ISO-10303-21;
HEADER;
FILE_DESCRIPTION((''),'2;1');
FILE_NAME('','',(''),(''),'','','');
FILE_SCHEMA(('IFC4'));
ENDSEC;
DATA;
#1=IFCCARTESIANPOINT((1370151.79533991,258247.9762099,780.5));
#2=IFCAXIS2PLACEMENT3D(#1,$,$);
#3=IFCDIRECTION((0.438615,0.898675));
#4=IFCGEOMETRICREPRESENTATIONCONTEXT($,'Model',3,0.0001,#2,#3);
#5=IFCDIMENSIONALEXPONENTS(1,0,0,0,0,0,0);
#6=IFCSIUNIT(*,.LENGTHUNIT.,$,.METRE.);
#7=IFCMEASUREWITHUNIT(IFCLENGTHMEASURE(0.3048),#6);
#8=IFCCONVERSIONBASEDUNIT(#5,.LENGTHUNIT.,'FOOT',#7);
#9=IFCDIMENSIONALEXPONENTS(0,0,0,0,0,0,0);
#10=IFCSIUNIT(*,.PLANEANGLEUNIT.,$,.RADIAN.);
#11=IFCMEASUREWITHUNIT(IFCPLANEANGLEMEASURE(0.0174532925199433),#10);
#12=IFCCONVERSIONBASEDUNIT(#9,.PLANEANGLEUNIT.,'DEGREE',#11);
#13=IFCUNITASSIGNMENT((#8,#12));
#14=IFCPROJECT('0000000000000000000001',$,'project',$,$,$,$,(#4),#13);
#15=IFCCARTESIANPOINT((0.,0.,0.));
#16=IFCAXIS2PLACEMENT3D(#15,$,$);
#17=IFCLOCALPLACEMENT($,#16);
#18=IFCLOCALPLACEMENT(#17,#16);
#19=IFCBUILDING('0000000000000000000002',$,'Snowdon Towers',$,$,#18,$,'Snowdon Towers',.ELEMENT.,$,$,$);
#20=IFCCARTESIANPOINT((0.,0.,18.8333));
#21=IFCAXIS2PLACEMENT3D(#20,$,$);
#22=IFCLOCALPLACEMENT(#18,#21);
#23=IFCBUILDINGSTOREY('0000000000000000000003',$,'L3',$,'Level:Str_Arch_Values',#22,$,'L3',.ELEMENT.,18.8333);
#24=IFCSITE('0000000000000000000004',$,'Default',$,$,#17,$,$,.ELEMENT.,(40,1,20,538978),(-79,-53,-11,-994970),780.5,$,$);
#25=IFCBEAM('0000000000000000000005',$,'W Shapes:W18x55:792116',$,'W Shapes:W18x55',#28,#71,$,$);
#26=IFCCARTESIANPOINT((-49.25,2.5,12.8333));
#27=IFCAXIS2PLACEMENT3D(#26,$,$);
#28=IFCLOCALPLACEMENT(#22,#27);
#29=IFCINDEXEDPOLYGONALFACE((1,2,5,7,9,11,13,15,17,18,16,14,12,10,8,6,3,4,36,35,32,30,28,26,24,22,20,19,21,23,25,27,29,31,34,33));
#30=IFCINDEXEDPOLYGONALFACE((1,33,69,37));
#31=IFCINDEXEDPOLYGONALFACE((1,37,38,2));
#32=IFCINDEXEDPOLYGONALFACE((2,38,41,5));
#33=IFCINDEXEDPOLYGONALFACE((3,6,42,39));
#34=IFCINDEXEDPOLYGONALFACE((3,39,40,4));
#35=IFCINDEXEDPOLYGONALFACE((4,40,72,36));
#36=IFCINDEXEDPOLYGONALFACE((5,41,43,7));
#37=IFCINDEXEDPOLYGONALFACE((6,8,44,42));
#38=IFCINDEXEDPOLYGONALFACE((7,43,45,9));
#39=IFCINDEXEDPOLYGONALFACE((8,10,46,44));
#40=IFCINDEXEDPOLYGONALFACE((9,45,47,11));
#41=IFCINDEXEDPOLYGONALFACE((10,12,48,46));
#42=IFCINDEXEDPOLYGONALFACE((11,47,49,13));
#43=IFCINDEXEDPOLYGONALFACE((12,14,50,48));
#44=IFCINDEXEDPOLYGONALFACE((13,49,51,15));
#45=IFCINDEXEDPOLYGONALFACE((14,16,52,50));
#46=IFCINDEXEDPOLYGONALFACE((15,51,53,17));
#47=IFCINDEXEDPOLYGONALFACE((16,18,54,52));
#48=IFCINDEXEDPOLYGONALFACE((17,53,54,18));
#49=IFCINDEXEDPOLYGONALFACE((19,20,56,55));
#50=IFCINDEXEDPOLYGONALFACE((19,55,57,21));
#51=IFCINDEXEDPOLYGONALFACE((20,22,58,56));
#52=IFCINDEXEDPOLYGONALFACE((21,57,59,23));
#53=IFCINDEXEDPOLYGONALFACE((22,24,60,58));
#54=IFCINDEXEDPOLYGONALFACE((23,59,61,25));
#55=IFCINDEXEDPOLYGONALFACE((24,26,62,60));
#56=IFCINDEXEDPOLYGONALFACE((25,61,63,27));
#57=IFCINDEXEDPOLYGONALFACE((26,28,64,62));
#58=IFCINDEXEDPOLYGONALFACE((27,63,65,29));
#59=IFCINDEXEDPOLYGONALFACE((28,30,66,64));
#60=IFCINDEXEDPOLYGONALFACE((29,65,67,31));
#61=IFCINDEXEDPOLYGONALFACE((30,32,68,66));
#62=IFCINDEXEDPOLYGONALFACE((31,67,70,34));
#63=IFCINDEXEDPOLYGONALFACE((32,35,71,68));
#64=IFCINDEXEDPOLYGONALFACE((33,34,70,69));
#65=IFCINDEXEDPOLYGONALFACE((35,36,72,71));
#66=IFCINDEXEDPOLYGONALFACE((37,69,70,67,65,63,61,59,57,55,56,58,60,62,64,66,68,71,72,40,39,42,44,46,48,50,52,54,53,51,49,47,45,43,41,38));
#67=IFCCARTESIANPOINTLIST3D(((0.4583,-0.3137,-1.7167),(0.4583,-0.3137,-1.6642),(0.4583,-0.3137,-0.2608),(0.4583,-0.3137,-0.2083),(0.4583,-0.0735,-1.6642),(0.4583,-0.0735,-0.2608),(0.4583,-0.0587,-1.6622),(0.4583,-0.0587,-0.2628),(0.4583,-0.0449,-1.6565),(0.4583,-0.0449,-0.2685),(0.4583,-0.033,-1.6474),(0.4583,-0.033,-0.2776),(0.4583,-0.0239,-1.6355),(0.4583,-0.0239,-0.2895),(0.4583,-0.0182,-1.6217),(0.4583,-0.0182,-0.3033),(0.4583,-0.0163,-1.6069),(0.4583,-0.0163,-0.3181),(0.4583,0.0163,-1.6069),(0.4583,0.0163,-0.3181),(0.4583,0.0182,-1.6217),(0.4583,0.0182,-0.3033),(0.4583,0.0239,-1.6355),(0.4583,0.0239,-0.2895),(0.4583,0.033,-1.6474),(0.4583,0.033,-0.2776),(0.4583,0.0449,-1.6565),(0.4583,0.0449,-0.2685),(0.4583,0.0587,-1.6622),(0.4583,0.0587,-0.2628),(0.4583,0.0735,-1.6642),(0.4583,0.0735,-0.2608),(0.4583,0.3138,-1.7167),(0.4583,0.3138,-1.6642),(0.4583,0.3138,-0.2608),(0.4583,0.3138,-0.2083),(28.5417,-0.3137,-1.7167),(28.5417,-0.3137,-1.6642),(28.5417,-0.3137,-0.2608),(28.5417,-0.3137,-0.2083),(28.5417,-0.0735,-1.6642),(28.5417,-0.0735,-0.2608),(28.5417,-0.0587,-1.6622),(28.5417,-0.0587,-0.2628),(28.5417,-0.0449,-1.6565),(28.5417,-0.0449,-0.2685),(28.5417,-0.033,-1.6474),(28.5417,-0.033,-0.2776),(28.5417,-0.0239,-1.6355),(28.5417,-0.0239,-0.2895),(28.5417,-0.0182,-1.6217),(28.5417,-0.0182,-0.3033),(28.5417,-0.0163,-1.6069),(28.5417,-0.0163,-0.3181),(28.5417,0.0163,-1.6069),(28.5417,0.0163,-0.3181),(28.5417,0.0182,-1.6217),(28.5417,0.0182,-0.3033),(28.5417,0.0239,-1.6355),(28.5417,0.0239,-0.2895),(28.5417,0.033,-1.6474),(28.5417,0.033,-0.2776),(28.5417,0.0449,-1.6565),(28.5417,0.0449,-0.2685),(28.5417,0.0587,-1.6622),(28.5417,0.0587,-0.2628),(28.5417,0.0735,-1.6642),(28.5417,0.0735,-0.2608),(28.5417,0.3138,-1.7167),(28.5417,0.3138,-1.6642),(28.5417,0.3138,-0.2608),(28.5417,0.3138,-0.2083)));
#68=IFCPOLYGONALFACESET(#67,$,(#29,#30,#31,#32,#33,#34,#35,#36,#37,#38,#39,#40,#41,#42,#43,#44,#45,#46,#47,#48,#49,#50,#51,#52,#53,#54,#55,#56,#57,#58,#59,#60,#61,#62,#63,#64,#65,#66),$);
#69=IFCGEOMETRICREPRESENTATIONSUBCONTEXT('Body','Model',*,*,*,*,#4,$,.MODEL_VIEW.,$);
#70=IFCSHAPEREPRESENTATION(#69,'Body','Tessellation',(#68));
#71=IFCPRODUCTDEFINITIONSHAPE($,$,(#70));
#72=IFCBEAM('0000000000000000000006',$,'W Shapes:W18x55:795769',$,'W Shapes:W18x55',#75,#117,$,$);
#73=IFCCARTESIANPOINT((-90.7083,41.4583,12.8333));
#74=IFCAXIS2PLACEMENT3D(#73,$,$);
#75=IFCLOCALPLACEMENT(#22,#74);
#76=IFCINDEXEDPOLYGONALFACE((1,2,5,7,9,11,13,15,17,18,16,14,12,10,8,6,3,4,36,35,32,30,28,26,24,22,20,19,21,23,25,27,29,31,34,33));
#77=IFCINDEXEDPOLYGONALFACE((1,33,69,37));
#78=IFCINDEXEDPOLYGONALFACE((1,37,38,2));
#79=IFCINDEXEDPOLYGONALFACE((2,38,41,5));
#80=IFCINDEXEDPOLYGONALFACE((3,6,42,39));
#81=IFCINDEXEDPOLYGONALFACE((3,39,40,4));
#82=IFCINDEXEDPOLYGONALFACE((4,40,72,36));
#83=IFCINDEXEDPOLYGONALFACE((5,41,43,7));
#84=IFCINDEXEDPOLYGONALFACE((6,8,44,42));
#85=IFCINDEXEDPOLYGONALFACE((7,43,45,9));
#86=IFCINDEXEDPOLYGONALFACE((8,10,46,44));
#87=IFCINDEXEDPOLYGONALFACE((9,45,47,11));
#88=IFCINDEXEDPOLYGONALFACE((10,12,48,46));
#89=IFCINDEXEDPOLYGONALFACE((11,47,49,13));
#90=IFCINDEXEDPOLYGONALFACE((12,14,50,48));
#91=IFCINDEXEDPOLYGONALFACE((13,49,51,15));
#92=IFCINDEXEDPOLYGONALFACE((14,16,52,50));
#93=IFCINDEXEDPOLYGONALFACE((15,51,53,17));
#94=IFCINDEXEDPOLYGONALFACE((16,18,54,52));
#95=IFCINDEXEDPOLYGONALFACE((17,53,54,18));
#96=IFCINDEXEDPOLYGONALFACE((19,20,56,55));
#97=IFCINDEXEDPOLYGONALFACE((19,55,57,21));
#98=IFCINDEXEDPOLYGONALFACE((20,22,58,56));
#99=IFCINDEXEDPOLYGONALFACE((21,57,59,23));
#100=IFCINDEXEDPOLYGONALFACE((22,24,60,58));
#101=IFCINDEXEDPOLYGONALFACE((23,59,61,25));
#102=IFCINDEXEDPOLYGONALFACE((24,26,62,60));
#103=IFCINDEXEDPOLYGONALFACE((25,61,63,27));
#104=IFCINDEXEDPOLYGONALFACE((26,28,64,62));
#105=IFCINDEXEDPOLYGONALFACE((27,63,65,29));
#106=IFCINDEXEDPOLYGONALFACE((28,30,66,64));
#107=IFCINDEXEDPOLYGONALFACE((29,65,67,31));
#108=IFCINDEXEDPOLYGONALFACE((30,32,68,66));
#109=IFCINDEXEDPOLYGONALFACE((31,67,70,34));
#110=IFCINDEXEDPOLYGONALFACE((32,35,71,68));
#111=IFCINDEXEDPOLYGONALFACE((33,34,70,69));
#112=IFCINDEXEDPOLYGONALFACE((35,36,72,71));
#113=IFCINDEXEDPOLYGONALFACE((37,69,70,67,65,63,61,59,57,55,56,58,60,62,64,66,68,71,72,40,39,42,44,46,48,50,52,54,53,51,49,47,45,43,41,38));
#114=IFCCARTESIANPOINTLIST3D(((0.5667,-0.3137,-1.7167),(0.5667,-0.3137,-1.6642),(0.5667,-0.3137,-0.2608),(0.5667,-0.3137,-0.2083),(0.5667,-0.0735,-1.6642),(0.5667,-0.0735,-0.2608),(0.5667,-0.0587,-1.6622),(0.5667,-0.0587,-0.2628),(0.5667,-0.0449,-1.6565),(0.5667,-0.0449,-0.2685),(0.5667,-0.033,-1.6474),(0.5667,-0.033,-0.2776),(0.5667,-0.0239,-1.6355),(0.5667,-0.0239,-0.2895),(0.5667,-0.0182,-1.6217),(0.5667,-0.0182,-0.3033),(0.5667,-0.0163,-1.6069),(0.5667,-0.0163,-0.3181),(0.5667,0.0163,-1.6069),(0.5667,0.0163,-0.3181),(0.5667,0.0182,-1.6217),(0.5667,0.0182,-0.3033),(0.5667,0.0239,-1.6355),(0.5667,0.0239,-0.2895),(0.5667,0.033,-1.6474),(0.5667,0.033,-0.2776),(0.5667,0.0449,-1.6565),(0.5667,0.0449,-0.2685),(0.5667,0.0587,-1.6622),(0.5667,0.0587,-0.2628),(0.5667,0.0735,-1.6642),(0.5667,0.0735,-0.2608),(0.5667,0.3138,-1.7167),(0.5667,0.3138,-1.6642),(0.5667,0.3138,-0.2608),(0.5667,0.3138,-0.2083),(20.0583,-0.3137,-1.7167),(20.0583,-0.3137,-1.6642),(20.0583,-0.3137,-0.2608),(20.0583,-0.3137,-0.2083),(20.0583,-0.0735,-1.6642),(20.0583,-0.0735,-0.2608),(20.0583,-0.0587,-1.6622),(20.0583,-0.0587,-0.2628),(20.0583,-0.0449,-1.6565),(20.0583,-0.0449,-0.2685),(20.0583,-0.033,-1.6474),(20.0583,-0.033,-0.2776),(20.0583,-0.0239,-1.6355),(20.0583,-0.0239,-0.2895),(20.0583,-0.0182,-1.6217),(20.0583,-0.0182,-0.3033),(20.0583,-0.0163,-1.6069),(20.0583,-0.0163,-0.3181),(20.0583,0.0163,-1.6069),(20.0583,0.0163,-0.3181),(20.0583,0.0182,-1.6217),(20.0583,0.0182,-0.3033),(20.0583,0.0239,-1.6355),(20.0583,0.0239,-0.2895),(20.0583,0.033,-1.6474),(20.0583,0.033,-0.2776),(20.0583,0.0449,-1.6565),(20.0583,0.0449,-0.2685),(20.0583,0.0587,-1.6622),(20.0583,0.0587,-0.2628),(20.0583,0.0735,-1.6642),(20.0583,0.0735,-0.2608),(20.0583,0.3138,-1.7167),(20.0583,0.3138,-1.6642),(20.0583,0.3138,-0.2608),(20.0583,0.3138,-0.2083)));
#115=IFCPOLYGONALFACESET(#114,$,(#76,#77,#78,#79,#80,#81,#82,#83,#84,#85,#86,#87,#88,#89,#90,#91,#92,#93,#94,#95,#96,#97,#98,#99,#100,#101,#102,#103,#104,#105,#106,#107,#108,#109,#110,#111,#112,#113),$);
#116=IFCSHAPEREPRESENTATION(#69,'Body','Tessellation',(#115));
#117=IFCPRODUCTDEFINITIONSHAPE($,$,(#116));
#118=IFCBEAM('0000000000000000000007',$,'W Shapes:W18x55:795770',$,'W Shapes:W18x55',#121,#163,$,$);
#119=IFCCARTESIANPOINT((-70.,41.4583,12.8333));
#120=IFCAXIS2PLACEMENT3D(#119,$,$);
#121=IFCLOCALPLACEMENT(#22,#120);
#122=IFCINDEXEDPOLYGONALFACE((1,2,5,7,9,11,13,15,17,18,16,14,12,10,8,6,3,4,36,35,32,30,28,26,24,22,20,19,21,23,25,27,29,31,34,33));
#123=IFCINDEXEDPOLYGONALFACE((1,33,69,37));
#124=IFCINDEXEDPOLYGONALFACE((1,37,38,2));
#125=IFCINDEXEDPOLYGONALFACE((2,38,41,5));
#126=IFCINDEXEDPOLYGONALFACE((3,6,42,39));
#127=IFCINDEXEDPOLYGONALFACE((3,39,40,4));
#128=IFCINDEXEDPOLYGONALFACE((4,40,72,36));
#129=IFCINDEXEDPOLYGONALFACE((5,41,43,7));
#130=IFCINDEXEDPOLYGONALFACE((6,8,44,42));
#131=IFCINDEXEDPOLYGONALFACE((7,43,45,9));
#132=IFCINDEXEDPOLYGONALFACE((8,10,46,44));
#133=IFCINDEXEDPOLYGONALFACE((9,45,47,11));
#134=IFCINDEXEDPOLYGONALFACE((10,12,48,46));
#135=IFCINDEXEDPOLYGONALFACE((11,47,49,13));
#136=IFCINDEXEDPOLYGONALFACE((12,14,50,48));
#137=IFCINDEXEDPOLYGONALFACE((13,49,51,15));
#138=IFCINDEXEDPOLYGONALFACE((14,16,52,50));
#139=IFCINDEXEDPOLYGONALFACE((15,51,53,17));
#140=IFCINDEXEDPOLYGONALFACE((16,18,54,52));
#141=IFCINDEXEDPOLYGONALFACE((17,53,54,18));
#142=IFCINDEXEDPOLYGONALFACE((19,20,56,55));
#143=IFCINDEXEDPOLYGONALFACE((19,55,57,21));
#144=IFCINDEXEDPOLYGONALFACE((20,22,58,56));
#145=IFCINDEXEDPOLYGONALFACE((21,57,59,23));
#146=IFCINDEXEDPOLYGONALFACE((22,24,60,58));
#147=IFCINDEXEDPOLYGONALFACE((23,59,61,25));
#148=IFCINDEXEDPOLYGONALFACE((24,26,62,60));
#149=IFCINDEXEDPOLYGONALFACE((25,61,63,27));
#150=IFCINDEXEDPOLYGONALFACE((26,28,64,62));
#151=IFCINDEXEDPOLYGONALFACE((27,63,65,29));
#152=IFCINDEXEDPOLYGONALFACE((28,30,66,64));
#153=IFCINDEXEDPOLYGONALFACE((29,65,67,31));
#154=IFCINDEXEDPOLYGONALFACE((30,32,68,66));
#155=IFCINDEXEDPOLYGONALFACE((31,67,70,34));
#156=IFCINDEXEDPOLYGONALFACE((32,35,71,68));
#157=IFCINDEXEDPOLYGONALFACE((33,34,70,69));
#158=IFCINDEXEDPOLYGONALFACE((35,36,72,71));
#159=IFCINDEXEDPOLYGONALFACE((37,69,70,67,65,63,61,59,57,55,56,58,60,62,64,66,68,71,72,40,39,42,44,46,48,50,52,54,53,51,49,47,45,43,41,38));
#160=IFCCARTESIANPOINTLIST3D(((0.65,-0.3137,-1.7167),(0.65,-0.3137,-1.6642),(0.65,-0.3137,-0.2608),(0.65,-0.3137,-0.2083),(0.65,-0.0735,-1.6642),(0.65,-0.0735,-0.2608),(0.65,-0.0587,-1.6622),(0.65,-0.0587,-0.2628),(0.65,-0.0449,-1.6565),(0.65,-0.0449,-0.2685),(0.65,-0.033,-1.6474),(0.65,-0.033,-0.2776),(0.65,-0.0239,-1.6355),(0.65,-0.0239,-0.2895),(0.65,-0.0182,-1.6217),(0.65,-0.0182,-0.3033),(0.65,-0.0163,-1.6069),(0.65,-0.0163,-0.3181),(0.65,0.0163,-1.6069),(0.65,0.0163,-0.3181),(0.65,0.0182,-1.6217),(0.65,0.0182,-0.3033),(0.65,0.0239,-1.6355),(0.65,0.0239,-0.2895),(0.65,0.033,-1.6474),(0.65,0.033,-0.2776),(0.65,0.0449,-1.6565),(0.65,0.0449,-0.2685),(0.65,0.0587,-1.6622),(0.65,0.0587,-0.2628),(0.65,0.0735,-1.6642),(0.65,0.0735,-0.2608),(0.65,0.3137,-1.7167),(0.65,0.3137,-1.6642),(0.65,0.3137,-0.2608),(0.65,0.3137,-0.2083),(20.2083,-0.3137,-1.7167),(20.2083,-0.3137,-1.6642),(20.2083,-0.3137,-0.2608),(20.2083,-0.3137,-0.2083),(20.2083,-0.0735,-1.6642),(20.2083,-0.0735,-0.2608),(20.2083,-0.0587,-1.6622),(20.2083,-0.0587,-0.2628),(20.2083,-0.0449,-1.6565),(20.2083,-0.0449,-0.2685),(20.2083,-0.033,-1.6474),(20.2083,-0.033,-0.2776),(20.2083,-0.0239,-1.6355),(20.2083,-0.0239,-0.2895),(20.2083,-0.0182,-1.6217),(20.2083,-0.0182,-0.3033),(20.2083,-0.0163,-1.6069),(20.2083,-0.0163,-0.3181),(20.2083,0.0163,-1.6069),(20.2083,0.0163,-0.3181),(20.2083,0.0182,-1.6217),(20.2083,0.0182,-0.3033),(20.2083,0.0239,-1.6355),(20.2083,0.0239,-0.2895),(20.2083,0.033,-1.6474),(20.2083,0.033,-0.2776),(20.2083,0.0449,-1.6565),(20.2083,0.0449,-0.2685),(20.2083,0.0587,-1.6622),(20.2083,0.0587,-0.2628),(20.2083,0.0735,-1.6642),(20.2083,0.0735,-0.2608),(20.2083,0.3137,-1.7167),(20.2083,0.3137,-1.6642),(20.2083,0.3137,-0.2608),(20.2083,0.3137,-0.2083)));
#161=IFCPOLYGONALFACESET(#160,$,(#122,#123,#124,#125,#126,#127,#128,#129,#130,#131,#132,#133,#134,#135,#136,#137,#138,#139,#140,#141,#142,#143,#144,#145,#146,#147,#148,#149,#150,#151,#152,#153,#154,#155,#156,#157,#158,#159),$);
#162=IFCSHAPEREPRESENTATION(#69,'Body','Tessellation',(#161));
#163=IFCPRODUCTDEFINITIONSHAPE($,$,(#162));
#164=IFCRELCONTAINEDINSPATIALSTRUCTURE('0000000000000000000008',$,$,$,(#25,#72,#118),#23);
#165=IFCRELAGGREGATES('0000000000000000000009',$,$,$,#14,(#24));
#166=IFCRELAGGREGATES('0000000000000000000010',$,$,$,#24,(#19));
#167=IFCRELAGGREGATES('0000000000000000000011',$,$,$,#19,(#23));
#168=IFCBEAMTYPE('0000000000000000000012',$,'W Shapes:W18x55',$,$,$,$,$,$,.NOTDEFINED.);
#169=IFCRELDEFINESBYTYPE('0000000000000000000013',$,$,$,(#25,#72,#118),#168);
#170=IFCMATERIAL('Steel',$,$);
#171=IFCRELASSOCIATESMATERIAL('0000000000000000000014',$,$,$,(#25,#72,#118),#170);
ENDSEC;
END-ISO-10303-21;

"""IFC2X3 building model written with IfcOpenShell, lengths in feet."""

from ifc_helpers import new_model, entity, si_unit, converted_unit, direction, frame, frame_2d, origin, place, context, subcontext, project, spatial, i_section, extrude, material, type_object, element, save


model = new_model("IFC2X3")

# Units and contexts
model_context = context("Model", 3, precision=0.0001, world=frame((1370151.79533991, 258247.9762099, 780.5)), true_north=direction((0.438615, 0.898675)))
body_context = subcontext(model_context, "Body", "Model", "MODEL_VIEW")
ifc_project = project(units=[converted_unit("LENGTHUNIT", "FOOT", entity("IfcLengthMeasure", 0.3048), si_unit("LENGTHUNIT", "METRE"), dimensions=[1, 0, 0, 0, 0, 0, 0]), converted_unit("PLANEANGLEUNIT", "DEGREE", entity("IfcPlaneAngleMeasure", 0.0174532925199433), si_unit("PLANEANGLEUNIT", "RADIAN"), dimensions=[0, 0, 0, 0, 0, 0, 0])], contexts=[model_context])

# Site, building, storey
site_placement = place(None, origin())
site = spatial("IfcSite", under=ifc_project, at=site_placement, Name="Default", CompositionType="ELEMENT", RefLatitude=(40, 1, 20, 538978), RefLongitude=(-79, -53, -11, -994970), RefElevation=780.5)
building_placement = place(site_placement, origin())
building = spatial("IfcBuilding", under=site, at=building_placement, Name="Snowdon Towers", LongName="Snowdon Towers", CompositionType="ELEMENT")
storey_placement = place(building_placement, frame((0.0, 0.0, 18.8333)))
storey = spatial("IfcBuildingStorey", under=building, at=storey_placement, Name="L3", ObjectType="Level:Str_Arch_Values", LongName="L3", CompositionType="ELEMENT", Elevation=18.8333)

# Shared definitions
ifc_material_1 = material(Name="Steel")

# Beams
beam_type_1 = type_object("IfcBeamType", Name="W Shapes:W18x55", PredefinedType="NOTDEFINED")
beam_1_placement = place(storey_placement, frame((-49.25, 2.5, 12.8333)))
element("IfcBeam", 1, at=beam_1_placement, inside=storey, type_object=beam_type_1, material=ifc_material_1, Name="W Shapes:W18x55:792116", ObjectType="W Shapes:W18x55", context=body_context, shape_type="SweptSolid", body=[
    extrude(i_section(OverallWidth=0.6275, OverallDepth=1.5083, WebThickness=0.0325, FlangeThickness=0.0525, FilletRadius=0.0573, at=frame_2d((0.0, 0.0), x_axis=(0.0, 1.0))), frame((0.4583, 0.0, -0.9625), z_axis=(1.0, 0.0, 0.0), x_axis=(0.0, 0.0, -1.0)), (0.0, 0.0, 1.0), 28.0833),
])
beam_2_placement = place(storey_placement, frame((-90.7083, 41.4583, 12.8333)))
element("IfcBeam", 2, at=beam_2_placement, inside=storey, type_object=beam_type_1, material=ifc_material_1, Name="W Shapes:W18x55:795769", ObjectType="W Shapes:W18x55", context=body_context, shape_type="SweptSolid", body=[
    extrude(i_section(OverallWidth=0.6275, OverallDepth=1.5083, WebThickness=0.0325, FlangeThickness=0.0525, FilletRadius=0.0573, at=frame_2d((0.0, 0.0), x_axis=(0.0, 1.0))), frame((0.5667, 0.0, -0.9625), z_axis=(1.0, 0.0, 0.0), x_axis=(0.0, 0.0, -1.0)), (0.0, 0.0, 1.0), 19.4917),
])
beam_3_placement = place(storey_placement, frame((-70.0, 41.4583, 12.8333)))
element("IfcBeam", 3, at=beam_3_placement, inside=storey, type_object=beam_type_1, material=ifc_material_1, Name="W Shapes:W18x55:795770", ObjectType="W Shapes:W18x55", context=body_context, shape_type="SweptSolid", body=[
    extrude(i_section(OverallWidth=0.6275, OverallDepth=1.5083, WebThickness=0.0325, FlangeThickness=0.0525, FilletRadius=0.0573, at=frame_2d((0.0, 0.0), x_axis=(0.0, 1.0))), frame((0.65, 0.0, -0.9625), z_axis=(1.0, 0.0, 0.0), x_axis=(0.0, 0.0, -1.0)), (0.0, 0.0, 1.0), 19.5583),
])

save(model, "model.ifc")
